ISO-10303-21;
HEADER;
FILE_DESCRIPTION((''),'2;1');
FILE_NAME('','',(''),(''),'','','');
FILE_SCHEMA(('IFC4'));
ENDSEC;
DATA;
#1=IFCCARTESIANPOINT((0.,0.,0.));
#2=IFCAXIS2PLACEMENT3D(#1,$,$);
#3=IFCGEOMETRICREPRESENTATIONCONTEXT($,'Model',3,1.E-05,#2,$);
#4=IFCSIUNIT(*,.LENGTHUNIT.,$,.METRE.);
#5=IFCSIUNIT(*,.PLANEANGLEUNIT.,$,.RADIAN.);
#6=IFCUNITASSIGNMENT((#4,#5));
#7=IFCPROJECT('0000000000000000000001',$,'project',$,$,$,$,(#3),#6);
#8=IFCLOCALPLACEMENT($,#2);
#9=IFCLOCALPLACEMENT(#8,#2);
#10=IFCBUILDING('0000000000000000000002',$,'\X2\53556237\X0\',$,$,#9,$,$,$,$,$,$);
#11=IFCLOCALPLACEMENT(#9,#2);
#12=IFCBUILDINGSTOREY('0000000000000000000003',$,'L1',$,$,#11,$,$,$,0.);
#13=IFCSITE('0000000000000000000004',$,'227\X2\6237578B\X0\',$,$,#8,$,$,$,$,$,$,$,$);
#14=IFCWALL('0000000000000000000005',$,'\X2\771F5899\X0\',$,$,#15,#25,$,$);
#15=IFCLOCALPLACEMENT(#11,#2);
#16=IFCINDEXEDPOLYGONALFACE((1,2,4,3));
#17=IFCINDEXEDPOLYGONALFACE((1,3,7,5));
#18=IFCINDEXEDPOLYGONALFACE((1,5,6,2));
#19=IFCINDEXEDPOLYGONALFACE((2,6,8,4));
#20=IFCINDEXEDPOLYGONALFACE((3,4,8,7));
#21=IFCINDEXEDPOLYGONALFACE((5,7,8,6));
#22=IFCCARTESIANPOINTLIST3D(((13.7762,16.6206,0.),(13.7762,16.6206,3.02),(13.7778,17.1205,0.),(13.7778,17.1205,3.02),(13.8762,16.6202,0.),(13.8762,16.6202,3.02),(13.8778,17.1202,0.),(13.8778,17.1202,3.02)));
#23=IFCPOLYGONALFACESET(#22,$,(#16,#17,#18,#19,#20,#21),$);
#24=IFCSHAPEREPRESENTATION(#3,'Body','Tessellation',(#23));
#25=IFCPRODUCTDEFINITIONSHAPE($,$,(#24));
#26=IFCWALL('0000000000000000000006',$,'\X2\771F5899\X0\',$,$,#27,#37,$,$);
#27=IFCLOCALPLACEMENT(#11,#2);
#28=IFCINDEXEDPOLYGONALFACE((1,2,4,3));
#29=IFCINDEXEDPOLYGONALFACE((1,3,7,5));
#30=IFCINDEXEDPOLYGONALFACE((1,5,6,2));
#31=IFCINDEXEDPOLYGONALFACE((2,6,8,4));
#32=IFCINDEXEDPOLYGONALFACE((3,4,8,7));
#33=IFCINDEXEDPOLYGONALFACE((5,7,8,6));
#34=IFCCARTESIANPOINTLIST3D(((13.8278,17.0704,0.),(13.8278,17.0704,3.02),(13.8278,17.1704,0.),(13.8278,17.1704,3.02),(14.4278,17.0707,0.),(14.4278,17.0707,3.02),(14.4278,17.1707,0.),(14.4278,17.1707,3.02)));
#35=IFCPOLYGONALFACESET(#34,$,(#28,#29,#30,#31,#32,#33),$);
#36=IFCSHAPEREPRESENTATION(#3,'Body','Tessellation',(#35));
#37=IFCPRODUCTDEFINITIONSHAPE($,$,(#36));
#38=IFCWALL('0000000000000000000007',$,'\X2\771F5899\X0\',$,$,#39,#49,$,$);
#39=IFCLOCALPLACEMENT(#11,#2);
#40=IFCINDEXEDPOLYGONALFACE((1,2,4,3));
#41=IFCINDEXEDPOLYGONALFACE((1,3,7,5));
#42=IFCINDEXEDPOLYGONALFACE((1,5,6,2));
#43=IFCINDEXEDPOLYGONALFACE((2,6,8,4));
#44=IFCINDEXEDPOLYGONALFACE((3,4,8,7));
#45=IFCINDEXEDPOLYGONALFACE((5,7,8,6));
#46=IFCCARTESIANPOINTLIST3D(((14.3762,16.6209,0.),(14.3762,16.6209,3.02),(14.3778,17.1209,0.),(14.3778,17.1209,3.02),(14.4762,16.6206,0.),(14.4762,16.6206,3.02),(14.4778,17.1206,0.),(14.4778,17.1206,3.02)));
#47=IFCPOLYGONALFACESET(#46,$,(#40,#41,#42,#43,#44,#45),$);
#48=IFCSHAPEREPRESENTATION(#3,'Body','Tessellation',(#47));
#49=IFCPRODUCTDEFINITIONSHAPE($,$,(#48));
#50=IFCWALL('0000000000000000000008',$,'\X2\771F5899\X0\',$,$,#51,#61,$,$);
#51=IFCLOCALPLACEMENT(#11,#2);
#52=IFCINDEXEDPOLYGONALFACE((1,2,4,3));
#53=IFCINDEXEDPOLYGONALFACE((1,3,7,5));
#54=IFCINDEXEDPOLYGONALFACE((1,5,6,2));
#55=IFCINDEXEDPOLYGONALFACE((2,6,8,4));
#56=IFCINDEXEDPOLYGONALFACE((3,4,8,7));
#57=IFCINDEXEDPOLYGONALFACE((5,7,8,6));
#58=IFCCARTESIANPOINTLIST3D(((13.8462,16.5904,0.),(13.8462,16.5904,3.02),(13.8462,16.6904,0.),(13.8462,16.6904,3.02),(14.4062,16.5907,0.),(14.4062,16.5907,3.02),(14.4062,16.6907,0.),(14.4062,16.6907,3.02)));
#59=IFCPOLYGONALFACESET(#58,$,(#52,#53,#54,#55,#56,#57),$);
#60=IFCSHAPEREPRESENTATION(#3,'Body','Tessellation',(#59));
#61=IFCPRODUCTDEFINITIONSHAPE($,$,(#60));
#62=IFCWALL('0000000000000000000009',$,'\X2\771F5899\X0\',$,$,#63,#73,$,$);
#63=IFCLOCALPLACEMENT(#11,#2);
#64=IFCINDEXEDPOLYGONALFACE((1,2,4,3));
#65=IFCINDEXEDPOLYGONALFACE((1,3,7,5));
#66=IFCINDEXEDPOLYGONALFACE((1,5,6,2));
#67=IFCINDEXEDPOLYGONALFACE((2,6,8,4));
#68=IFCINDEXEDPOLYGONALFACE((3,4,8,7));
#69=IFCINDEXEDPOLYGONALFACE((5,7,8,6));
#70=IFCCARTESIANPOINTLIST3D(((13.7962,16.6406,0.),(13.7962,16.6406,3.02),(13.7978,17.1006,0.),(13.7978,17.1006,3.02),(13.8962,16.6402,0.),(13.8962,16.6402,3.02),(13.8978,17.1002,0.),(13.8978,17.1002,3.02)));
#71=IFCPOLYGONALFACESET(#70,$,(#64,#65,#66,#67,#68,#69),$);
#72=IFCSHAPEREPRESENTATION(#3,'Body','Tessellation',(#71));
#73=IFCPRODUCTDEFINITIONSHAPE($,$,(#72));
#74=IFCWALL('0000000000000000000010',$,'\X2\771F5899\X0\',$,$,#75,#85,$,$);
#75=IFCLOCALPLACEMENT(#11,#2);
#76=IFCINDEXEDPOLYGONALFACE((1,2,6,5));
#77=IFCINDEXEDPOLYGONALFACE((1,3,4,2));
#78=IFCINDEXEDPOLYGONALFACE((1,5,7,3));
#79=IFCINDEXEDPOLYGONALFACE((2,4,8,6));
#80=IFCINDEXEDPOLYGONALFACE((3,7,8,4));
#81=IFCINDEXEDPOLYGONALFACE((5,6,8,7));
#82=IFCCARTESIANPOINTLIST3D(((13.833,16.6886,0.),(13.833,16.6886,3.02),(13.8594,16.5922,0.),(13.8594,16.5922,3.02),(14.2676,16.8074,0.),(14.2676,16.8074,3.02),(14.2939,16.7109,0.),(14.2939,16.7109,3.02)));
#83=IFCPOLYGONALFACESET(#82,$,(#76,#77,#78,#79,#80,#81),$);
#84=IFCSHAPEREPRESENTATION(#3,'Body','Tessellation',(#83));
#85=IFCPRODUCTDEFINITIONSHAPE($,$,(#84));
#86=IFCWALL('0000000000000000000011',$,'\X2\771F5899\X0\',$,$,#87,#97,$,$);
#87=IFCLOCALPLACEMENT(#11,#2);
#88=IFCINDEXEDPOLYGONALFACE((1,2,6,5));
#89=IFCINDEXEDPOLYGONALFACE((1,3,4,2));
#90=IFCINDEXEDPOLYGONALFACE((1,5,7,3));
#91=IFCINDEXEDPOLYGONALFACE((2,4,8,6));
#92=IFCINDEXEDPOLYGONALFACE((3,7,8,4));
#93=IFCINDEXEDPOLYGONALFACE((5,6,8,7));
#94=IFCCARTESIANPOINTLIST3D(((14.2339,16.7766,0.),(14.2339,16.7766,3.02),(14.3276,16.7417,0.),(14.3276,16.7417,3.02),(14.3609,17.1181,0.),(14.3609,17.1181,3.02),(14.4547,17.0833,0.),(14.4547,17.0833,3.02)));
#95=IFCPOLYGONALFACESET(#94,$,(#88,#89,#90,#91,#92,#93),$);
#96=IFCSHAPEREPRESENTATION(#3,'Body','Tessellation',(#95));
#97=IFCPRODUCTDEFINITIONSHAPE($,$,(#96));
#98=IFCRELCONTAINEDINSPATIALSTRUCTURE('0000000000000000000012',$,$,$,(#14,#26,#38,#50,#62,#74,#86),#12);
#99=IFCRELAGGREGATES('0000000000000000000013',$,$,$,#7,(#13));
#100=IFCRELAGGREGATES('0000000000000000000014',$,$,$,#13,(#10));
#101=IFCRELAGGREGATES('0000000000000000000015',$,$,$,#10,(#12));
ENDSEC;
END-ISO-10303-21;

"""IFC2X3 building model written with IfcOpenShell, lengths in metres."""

from ifc_helpers import new_model, si_unit, origin, place, context, project, spatial, polyline, outline, extrude, element, save


model = new_model("IFC2X3")

# Units and contexts
model_context = context("Model", 3, precision=1e-05, world=origin())
ifc_project = project(units=[si_unit("LENGTHUNIT", "METRE"), si_unit("PLANEANGLEUNIT", "RADIAN")], contexts=[model_context])

# Site, building, storey
site_placement = place(None, origin())
site = spatial("IfcSite", under=ifc_project, at=site_placement, Name="227户型")
building_placement = place(site_placement, origin())
building = spatial("IfcBuilding", under=site, at=building_placement, Name="单户")
storey_placement = place(building_placement, origin())
storey = spatial("IfcBuildingStorey", under=building, at=storey_placement, Name="L1", Elevation=0.0)

# Walls
wall_1_placement = place(storey_placement, origin())
element("IfcWall", 1, at=wall_1_placement, inside=storey, Name="真墙", context=model_context, shape_type="SweptSolid", body=[
    extrude(outline(polyline([(13.7762, 16.6206), (13.7778, 17.1205), (13.8778, 17.1202), (13.8762, 16.6202), (13.7762, 16.6206)])), origin(), (0.0, 0.0, 1.0), 3.02),
])
wall_2_placement = place(storey_placement, origin())
element("IfcWall", 2, at=wall_2_placement, inside=storey, Name="真墙", context=model_context, shape_type="SweptSolid", body=[
    extrude(outline(polyline([(13.8278, 17.1704), (14.4278, 17.1707), (14.4278, 17.0707), (13.8278, 17.0704), (13.8278, 17.1704)])), origin(), (0.0, 0.0, 1.0), 3.02),
])
wall_3_placement = place(storey_placement, origin())
element("IfcWall", 3, at=wall_3_placement, inside=storey, Name="真墙", context=model_context, shape_type="SweptSolid", body=[
    extrude(outline(polyline([(14.4778, 17.1206), (14.4762, 16.6206), (14.3762, 16.6209), (14.3778, 17.1209), (14.4778, 17.1206)])), origin(), (0.0, 0.0, 1.0), 3.02),
])
wall_4_placement = place(storey_placement, origin())
element("IfcWall", 4, at=wall_4_placement, inside=storey, Name="真墙", context=model_context, shape_type="SweptSolid", body=[
    extrude(outline(polyline([(14.4062, 16.5907), (13.8462, 16.5904), (13.8462, 16.6904), (14.4062, 16.6907), (14.4062, 16.5907)])), origin(), (0.0, 0.0, 1.0), 3.02),
])
wall_5_placement = place(storey_placement, origin())
element("IfcWall", 5, at=wall_5_placement, inside=storey, Name="真墙", context=model_context, shape_type="SweptSolid", body=[
    extrude(outline(polyline([(13.7962, 16.6406), (13.7978, 17.1006), (13.8978, 17.1002), (13.8962, 16.6402), (13.7962, 16.6406)])), origin(), (0.0, 0.0, 1.0), 3.02),
])

# Walls
wall_6_placement = place(storey_placement, origin())
element("IfcWall", 6, at=wall_6_placement, inside=storey, Name="真墙", context=model_context, shape_type="SweptSolid", body=[
    extrude(outline(polyline([(13.833, 16.6886), (14.2676, 16.8074), (14.2939, 16.7109), (13.8594, 16.5922), (13.833, 16.6886)])), origin(), (0.0, 0.0, 1.0), 3.02),
])
wall_7_placement = place(storey_placement, origin())
element("IfcWall", 7, at=wall_7_placement, inside=storey, Name="真墙", context=model_context, shape_type="SweptSolid", body=[
    extrude(outline(polyline([(14.2339, 16.7766), (14.3609, 17.1181), (14.4547, 17.0833), (14.3276, 16.7417), (14.2339, 16.7766)])), origin(), (0.0, 0.0, 1.0), 3.02),
])

save(model, "model.ifc")
